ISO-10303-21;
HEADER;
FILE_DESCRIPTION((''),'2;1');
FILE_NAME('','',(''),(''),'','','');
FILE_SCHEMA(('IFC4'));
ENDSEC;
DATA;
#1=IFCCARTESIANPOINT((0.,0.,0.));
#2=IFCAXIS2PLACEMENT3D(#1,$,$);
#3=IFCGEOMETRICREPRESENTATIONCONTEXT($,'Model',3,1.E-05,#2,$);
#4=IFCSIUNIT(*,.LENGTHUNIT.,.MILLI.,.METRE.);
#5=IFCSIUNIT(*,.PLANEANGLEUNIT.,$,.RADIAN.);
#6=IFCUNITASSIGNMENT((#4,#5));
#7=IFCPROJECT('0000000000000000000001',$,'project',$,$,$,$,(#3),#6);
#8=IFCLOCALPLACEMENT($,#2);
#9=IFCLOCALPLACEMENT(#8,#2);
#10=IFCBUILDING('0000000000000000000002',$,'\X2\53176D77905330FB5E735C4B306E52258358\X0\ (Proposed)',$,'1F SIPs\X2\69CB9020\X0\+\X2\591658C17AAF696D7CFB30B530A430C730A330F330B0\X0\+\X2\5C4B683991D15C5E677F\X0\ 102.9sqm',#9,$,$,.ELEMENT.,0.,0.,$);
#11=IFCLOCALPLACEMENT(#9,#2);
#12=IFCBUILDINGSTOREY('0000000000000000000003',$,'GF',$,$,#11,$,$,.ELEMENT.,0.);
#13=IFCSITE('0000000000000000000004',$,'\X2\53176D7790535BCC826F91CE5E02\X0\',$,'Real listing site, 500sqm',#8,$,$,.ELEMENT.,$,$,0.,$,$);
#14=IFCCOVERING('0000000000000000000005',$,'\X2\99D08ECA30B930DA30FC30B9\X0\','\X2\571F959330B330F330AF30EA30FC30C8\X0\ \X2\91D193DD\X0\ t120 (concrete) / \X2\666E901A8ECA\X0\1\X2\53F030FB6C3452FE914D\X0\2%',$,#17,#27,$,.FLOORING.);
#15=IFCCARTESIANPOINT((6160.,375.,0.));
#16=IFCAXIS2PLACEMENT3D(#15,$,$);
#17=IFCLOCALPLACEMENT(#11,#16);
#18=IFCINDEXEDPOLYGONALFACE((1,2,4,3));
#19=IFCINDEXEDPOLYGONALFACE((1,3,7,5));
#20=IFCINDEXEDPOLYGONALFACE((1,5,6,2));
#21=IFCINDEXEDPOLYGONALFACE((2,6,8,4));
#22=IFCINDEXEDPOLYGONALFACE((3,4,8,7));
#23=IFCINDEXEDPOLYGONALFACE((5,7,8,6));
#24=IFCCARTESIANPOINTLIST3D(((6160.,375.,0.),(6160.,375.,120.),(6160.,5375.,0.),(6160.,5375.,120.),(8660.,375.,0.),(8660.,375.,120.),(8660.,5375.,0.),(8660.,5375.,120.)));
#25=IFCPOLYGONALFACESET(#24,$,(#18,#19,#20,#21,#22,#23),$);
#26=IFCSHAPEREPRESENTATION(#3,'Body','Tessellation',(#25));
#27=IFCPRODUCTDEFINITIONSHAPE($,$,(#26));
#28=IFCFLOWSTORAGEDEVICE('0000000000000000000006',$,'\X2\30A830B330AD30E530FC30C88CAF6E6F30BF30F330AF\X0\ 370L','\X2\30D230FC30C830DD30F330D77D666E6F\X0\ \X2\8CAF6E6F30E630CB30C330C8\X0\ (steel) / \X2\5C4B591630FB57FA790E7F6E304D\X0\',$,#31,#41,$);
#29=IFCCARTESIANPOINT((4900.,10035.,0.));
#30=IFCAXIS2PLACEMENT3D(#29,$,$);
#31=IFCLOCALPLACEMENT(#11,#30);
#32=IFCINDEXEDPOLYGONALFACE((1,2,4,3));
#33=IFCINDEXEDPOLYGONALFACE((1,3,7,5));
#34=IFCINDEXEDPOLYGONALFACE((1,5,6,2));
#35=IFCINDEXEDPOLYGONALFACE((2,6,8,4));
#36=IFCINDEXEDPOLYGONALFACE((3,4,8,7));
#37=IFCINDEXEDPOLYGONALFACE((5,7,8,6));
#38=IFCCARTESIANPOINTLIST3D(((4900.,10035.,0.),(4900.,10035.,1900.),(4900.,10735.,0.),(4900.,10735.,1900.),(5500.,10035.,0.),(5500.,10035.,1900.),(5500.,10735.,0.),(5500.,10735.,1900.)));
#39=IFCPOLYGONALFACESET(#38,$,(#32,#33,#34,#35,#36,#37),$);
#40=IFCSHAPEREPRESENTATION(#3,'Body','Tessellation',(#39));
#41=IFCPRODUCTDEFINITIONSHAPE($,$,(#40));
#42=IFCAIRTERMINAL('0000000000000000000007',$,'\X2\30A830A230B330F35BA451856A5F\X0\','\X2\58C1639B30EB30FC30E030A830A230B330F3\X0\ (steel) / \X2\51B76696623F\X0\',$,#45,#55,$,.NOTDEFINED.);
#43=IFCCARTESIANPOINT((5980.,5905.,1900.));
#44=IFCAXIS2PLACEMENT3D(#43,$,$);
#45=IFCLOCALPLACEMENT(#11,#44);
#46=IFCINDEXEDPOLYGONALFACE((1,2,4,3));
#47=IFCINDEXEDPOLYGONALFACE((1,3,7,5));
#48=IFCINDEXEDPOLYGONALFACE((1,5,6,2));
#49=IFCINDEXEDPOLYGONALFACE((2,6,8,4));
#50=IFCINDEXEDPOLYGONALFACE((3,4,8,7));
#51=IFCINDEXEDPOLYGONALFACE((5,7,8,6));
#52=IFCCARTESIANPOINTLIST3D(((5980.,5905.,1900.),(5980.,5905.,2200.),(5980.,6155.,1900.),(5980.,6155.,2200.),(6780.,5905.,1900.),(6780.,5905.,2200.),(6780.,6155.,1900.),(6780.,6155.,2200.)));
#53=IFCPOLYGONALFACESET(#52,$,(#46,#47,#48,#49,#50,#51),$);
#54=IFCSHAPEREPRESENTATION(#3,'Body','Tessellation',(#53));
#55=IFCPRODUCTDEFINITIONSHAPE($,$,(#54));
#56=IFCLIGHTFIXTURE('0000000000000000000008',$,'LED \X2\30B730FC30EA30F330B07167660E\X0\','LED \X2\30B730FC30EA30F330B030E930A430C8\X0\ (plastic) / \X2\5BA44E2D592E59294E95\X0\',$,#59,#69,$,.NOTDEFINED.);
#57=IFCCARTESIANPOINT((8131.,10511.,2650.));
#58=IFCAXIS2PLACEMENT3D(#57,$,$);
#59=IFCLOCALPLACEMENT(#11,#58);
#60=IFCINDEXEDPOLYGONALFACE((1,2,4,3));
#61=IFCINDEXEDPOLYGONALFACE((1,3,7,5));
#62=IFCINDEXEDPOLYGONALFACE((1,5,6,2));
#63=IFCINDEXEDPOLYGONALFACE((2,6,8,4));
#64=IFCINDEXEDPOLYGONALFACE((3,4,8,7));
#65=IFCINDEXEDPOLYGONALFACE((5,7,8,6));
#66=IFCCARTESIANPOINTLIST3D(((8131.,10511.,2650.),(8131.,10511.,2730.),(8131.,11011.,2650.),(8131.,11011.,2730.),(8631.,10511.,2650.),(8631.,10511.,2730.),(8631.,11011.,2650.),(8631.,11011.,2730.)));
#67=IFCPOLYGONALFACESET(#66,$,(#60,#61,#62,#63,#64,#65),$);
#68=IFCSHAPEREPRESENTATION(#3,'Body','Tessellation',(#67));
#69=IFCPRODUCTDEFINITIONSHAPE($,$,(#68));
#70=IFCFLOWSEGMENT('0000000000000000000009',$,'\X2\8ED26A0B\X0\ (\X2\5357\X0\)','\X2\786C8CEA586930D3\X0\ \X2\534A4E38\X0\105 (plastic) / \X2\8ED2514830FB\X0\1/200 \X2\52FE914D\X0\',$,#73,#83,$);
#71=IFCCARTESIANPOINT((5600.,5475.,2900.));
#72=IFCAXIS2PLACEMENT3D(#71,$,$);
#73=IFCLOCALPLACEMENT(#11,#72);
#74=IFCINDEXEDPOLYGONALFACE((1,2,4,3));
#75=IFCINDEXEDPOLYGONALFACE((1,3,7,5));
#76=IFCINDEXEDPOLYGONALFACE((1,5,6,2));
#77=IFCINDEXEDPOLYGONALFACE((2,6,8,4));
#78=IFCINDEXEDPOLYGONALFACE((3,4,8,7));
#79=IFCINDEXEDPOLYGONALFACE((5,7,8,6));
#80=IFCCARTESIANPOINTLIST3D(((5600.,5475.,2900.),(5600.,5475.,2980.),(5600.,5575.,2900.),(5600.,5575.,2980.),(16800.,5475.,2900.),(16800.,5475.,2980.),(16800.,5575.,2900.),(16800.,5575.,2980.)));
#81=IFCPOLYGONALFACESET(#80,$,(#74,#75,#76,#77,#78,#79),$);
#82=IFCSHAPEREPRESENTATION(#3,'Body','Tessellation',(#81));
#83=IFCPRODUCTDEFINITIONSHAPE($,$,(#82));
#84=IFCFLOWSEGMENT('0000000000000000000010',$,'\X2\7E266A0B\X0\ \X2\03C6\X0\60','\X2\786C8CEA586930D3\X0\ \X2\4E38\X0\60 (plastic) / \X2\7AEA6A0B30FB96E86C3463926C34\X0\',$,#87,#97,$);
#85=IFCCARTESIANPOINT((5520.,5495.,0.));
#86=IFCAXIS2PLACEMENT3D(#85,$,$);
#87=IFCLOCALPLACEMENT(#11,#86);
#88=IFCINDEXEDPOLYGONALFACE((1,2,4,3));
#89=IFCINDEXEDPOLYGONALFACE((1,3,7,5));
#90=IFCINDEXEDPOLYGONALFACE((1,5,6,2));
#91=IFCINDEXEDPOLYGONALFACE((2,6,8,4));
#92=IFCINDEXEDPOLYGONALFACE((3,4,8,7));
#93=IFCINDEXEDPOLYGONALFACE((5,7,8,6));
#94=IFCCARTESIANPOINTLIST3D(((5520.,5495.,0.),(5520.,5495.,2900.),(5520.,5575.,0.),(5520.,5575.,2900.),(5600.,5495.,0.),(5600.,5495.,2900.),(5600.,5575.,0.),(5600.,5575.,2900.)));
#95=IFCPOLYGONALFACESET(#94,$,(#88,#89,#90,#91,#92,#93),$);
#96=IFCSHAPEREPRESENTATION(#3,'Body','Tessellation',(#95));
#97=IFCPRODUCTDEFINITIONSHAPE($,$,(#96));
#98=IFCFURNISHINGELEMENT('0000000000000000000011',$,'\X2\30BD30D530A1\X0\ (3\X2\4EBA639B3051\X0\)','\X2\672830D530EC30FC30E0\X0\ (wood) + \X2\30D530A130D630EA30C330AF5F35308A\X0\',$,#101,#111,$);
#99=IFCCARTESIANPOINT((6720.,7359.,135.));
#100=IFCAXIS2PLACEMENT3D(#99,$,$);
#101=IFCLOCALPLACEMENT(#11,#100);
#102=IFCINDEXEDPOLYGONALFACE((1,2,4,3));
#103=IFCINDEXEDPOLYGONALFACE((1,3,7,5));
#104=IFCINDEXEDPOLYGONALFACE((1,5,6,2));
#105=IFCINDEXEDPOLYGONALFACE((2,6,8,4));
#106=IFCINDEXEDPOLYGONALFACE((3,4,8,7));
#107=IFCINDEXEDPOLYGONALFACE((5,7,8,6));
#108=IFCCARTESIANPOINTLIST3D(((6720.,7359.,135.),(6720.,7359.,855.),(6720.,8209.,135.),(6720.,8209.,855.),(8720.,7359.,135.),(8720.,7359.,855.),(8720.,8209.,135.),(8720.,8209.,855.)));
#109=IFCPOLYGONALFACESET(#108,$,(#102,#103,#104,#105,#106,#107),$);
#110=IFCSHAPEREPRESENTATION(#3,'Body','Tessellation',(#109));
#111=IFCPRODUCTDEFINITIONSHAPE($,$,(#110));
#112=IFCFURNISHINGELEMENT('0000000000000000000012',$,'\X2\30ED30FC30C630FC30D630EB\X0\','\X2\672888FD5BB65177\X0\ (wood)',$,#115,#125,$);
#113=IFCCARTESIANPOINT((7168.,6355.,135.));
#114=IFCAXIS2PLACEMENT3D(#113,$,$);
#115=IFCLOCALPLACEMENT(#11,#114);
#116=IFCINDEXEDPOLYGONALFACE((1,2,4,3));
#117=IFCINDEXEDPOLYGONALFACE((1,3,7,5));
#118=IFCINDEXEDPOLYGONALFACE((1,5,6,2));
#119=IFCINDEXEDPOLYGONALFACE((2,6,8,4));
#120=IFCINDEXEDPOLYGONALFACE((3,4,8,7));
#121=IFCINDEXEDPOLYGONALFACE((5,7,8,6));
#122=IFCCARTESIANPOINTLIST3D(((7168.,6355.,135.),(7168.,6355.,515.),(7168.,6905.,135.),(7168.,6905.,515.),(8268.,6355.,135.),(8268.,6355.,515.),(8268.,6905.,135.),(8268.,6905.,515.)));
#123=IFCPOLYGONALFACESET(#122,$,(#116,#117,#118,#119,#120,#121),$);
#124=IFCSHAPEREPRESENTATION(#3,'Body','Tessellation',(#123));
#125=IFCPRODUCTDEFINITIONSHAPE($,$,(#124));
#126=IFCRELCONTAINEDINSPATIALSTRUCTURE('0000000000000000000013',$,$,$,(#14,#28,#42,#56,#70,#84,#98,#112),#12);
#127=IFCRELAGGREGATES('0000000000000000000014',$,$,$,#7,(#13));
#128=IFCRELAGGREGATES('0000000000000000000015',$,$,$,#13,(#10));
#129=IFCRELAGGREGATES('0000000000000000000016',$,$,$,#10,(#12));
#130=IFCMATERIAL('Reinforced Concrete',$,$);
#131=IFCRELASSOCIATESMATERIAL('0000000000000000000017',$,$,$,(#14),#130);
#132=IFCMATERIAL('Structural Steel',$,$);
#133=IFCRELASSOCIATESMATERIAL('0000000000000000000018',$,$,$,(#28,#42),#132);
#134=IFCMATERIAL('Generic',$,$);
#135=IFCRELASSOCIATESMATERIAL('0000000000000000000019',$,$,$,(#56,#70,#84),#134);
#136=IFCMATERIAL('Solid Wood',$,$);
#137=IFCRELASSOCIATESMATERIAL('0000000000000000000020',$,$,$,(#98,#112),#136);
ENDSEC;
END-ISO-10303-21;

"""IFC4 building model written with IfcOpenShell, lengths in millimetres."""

from ifc_helpers import new_model, si_unit, frame, frame_2d, origin, place, context, project, spatial, rectangle, extrude, material, element, save


model = new_model("IFC4")

# Units and contexts
model_context = context("Model", 3, precision=1e-05, world=origin())
ifc_project = project(units=[si_unit("LENGTHUNIT", "METRE", prefix="MILLI"), si_unit("PLANEANGLEUNIT", "RADIAN")], contexts=[model_context])

# Site, building, storey
site_placement = place(None, origin())
site = spatial("IfcSite", under=ifc_project, at=site_placement, Name="北海道富良野市", ObjectType="Real listing site, 500sqm", CompositionType="ELEMENT", RefElevation=0.0)
building_placement = place(site_placement, origin())
building = spatial("IfcBuilding", under=site, at=building_placement, Name="北海道・平屋の別荘 (Proposed)", ObjectType="1F SIPs構造+外壁窯業系サイディング+屋根金属板 102.9sqm", CompositionType="ELEMENT", ElevationOfRefHeight=0.0, ElevationOfTerrain=0.0)
storey_placement = place(building_placement, origin())
storey = spatial("IfcBuildingStorey", under=building, at=storey_placement, Name="GF", CompositionType="ELEMENT", Elevation=0.0)

# Shared definitions
ifc_material_1 = material(Name="Solid Wood")

# Shared definitions
ifc_material_2 = material(Name="Reinforced Concrete")

# Shared definitions
ifc_material_3 = material(Name="Structural Steel")

# Covering
ifc_material_4 = material(Name="Generic")
covering_1_placement = place(storey_placement, frame((6160.0, 375.0, 0.0)))
element("IfcCovering", 1, at=covering_1_placement, inside=storey, material=ifc_material_2, Name="駐車スペース", Description="土間コンクリート 金鏝 t120 (concrete) / 普通車1台・水勾配2%", PredefinedType="FLOORING", context=model_context, shape_type="SweptSolid", body=[
    extrude(rectangle(XDim=2500.0, YDim=5000.0, at=frame_2d((1250.0, 2500.0))), frame((6160.0, 375.0, 0.0)), (0.0, 0.0, 1.0), 120.0),
])

# Flow storage device
flow_storage_device_placement = place(storey_placement, frame((4900.0, 10035.0, 0.0)))
element("IfcFlowStorageDevice", 2, at=flow_storage_device_placement, inside=storey, material=ifc_material_3, Name="エコキュート貯湯タンク 370L", Description="ヒートポンプ給湯 貯湯ユニット (steel) / 屋外・基礎置き", context=model_context, shape_type="SweptSolid", body=[
    extrude(rectangle(XDim=600.0, YDim=700.0, at=frame_2d((300.0, 350.0))), frame((4900.0, 10035.0, 0.0)), (0.0, 0.0, 1.0), 1900.0),
])

# Air terminal
air_terminal_placement = place(storey_placement, frame((5980.0, 5905.0, 1900.0)))
element("IfcAirTerminal", 3, at=air_terminal_placement, inside=storey, material=ifc_material_3, Name="エアコン室内機", Description="壁掛ルームエアコン (steel) / 冷暖房", PredefinedType="NOTDEFINED", context=model_context, shape_type="SweptSolid", body=[
    extrude(rectangle(XDim=800.0, YDim=250.0, at=frame_2d((400.0, 125.0))), frame((5980.0, 5905.0, 1900.0)), (0.0, 0.0, 1.0), 300.0),
])

# Light fixture
light_fixture_placement = place(storey_placement, frame((8131.0, 10511.0, 2650.0)))
element("IfcLightFixture", 4, at=light_fixture_placement, inside=storey, material=ifc_material_4, Name="LED シーリング照明", Description="LED シーリングライト (plastic) / 室中央天井", PredefinedType="NOTDEFINED", context=model_context, shape_type="SweptSolid", body=[
    extrude(rectangle(XDim=500.0, YDim=500.0, at=frame_2d((250.0, 250.0))), frame((8131.0, 10511.0, 2650.0)), (0.0, 0.0, 1.0), 80.0),
])

# Flow segments
flow_segment_1_placement = place(storey_placement, frame((5600.0, 5475.0, 2900.0)))
element("IfcFlowSegment", 5, at=flow_segment_1_placement, inside=storey, material=ifc_material_4, Name="軒樋 (南)", Description="硬質塩ビ 半丸105 (plastic) / 軒先・1/200 勾配", context=model_context, shape_type="SweptSolid", body=[
    extrude(rectangle(XDim=11200.0, YDim=100.0, at=frame_2d((5600.0, 50.0))), frame((5600.0, 5475.0, 2900.0)), (0.0, 0.0, 1.0), 80.0),
])
flow_segment_2_placement = place(storey_placement, frame((5520.0, 5495.0, 0.0)))
element("IfcFlowSegment", 6, at=flow_segment_2_placement, inside=storey, material=ifc_material_4, Name="縦樋 φ60", Description="硬質塩ビ 丸60 (plastic) / 竪樋・雨水排水", context=model_context, shape_type="SweptSolid", body=[
    extrude(rectangle(XDim=80.0, YDim=80.0, at=frame_2d((40.0, 40.0))), frame((5520.0, 5495.0, 0.0)), (0.0, 0.0, 1.0), 2900.0),
])

# Furnishing elements
furnishing_1_placement = place(storey_placement, frame((6720.0, 7359.0, 135.0)))
element("IfcFurnishingElement", 7, at=furnishing_1_placement, inside=storey, material=ifc_material_1, Name="ソファ (3人掛け)", Description="木フレーム (wood) + ファブリック張り", context=model_context, shape_type="SweptSolid", body=[
    extrude(rectangle(XDim=2000.0, YDim=850.0, at=frame_2d((1000.0, 425.0))), frame((6720.0, 7359.0, 135.0)), (0.0, 0.0, 1.0), 720.0),
])
furnishing_2_placement = place(storey_placement, frame((7168.0, 6355.0, 135.0)))
element("IfcFurnishingElement", 8, at=furnishing_2_placement, inside=storey, material=ifc_material_1, Name="ローテーブル", Description="木製家具 (wood)", context=model_context, shape_type="SweptSolid", body=[
    extrude(rectangle(XDim=1100.0, YDim=550.0, at=frame_2d((550.0, 275.0))), frame((7168.0, 6355.0, 135.0)), (0.0, 0.0, 1.0), 380.0),
])

save(model, "model.ifc")
